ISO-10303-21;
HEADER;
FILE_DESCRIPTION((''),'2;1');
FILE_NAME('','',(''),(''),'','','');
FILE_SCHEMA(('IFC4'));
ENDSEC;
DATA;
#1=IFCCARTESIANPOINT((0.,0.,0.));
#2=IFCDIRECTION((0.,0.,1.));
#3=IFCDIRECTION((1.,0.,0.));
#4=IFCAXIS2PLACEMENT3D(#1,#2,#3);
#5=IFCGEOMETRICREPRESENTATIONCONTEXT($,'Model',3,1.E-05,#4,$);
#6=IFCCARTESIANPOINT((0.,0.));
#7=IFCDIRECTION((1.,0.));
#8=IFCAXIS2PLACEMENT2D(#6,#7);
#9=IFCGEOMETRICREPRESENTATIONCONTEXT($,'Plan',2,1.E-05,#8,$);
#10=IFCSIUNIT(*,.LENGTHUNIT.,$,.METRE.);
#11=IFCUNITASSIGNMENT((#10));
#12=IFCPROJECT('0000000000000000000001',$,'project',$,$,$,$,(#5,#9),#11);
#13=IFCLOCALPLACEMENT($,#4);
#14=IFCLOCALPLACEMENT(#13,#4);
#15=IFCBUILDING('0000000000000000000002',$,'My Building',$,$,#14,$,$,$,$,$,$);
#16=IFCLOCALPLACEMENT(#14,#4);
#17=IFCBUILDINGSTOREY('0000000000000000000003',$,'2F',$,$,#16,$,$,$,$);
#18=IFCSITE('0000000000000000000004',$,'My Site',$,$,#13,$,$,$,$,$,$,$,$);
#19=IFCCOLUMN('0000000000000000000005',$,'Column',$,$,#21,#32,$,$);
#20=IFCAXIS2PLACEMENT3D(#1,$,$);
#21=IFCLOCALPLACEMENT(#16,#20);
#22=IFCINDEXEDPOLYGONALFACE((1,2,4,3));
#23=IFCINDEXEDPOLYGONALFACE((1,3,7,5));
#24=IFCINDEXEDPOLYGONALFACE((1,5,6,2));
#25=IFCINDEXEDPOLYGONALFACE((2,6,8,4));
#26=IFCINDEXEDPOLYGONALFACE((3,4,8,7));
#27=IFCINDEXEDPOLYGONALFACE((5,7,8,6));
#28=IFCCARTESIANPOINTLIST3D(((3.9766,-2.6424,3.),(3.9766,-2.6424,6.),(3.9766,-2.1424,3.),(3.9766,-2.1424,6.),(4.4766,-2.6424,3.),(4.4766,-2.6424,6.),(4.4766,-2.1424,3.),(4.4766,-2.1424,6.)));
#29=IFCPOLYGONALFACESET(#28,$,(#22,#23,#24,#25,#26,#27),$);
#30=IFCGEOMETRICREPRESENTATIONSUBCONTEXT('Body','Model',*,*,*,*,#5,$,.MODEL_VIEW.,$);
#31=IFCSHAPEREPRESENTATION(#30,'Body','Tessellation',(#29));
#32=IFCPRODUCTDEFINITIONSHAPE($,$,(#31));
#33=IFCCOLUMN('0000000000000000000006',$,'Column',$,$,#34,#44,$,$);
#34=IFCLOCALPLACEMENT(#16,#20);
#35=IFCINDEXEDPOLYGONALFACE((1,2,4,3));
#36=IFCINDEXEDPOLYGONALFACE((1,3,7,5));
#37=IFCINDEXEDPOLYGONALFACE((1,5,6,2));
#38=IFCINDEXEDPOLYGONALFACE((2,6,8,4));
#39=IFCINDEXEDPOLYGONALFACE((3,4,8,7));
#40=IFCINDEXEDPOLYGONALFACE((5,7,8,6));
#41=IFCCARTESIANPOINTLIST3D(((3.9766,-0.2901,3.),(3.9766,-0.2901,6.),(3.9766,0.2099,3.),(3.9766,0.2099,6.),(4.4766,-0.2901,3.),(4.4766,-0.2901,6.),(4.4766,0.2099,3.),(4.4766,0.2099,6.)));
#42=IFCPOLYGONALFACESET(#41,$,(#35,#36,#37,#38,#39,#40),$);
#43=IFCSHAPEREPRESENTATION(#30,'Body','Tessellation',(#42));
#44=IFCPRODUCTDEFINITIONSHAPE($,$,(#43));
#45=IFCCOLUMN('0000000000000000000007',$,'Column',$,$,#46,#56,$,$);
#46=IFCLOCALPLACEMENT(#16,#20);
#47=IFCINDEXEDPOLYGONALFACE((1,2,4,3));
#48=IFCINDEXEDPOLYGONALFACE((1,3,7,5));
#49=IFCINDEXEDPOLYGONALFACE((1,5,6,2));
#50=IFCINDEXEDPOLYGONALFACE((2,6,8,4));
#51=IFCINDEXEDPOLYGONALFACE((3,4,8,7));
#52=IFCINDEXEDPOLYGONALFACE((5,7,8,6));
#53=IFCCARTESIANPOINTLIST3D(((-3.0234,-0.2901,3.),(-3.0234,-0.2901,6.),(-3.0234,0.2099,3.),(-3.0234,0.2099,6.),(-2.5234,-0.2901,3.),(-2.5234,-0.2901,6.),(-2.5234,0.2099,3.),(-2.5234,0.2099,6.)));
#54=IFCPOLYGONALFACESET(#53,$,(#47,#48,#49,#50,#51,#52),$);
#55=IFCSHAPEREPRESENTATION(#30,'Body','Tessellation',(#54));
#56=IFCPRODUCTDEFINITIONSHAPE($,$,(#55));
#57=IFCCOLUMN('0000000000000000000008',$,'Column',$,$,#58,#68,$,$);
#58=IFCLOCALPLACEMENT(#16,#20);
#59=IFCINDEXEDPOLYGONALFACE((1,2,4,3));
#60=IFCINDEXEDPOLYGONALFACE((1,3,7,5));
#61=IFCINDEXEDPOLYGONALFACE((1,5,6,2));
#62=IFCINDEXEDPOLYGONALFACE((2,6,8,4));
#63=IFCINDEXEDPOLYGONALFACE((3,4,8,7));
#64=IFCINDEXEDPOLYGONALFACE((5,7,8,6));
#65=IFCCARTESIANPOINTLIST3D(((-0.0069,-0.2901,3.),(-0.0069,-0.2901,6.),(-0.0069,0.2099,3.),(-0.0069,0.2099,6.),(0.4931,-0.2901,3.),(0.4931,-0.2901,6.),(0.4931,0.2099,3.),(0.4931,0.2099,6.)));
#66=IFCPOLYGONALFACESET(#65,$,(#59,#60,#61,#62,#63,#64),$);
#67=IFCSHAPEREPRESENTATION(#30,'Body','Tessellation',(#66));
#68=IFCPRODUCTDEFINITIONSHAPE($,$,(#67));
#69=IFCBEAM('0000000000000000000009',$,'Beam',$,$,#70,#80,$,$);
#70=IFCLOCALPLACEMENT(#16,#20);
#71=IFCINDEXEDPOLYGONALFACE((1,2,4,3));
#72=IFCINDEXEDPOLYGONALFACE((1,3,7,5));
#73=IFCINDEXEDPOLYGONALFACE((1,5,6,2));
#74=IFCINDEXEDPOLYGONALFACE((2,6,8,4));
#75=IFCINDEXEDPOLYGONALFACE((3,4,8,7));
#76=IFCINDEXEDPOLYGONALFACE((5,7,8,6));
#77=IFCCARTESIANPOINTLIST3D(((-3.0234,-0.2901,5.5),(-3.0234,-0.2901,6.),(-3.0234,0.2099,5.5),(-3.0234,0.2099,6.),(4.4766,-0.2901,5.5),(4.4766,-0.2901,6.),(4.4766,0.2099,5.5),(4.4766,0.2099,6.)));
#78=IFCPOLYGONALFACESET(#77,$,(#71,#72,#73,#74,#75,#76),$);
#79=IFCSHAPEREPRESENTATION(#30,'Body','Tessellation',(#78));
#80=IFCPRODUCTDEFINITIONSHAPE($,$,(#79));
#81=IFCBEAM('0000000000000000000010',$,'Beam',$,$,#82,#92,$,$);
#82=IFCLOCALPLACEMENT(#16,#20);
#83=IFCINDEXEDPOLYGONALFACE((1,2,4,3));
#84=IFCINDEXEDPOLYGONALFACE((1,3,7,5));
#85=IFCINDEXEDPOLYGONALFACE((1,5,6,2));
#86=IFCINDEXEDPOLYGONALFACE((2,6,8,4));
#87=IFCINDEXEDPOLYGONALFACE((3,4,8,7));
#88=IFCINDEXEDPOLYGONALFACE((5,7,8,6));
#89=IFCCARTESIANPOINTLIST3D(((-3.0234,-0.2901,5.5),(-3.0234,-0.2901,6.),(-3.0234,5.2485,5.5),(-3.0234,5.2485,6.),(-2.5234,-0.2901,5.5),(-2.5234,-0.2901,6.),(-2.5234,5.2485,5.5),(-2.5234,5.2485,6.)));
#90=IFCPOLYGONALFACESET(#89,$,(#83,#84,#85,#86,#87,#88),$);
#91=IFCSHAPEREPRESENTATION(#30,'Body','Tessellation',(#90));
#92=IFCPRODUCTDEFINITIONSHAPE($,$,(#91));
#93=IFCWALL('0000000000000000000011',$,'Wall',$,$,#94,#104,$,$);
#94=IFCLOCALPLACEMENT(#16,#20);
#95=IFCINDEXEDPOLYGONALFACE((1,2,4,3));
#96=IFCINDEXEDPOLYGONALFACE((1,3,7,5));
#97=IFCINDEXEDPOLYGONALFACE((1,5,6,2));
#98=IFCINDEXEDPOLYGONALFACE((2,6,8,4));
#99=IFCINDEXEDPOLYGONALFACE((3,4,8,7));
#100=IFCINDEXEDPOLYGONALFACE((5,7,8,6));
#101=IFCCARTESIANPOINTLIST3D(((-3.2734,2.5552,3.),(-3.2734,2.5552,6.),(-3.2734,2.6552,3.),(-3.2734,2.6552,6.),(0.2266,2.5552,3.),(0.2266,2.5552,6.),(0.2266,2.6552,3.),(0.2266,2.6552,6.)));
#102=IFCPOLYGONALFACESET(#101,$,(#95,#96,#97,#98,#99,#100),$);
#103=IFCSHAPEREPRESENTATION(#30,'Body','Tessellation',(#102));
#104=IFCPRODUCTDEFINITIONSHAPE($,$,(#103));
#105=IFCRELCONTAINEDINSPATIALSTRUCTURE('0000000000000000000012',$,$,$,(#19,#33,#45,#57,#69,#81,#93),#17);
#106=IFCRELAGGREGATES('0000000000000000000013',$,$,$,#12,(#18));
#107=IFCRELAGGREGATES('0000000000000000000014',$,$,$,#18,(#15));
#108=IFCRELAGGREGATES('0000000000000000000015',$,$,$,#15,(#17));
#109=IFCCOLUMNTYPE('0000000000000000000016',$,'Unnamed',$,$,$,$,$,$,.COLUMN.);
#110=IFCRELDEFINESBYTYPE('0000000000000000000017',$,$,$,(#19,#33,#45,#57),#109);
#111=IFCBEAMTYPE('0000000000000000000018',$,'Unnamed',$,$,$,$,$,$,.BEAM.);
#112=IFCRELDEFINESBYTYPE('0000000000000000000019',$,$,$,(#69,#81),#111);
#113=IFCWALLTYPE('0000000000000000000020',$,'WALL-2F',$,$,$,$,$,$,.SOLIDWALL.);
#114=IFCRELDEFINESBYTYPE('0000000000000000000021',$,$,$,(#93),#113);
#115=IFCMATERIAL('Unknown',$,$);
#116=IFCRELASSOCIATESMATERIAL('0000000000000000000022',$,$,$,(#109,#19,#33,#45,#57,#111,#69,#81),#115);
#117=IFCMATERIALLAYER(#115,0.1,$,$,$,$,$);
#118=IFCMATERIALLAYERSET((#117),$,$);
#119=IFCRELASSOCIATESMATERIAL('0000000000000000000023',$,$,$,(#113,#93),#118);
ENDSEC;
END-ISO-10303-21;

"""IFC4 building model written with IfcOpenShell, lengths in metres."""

from ifc_helpers import new_model, si_unit, frame, origin_with_axes, origin_2d_with_axis, place, context, subcontext, project, spatial, line, indexed_curve, rectangle, outline, extrude, material, layer, layer_set, layer_usage, material_profile, profile_set, profile_usage, type_object, element, save


model = new_model("IFC4")

# Units and contexts
model_context = context("Model", 3, precision=1e-05, world=origin_with_axes())
plan_context = context("Plan", 2, precision=1e-05, world=origin_2d_with_axis())
body_context_1 = subcontext(model_context, "Body", "Model", "MODEL_VIEW")
ifc_project = project(units=[si_unit("LENGTHUNIT", "METRE")], contexts=[model_context, plan_context])

# Site, building, storey
site_placement = place(None, origin_with_axes())
site = spatial("IfcSite", under=ifc_project, at=site_placement, Name="My Site")
building_placement = place(site_placement, origin_with_axes())
building = spatial("IfcBuilding", under=site, at=building_placement, Name="My Building")
storey_placement = place(building_placement, origin_with_axes())
storey = spatial("IfcBuildingStorey", under=building, at=storey_placement, Name="2F")

# Columns
ifc_material = material(Name="Unknown")
ifc_material_profile_1 = material_profile(ifc_material, rectangle(XDim=0.5, YDim=0.5))
ifc_profile_set_1 = profile_set([ifc_material_profile_1])
ifc_profile_usage_1 = profile_usage(ifc_profile_set_1, cardinal=7)
column_type = type_object("IfcColumnType", Name="Unnamed", PredefinedType="COLUMN", material=ifc_profile_set_1)
column_1_placement = place(storey_placement, frame((4.4766, -2.1424, 3.0), z_axis=(0.0, 0.0, 1.0), x_axis=(1.0, 0.0, 0.0)))
element("IfcColumn", 1, at=column_1_placement, inside=storey, type_object=column_type, material=ifc_profile_usage_1, Name="Column", context=body_context_1, shape_type="SweptSolid", body=[
    extrude(rectangle(XDim=0.5, YDim=0.5), frame((-0.25, -0.25, 0.0), z_axis=(0.0, 0.0, 1.0), x_axis=(1.0, 0.0, 0.0)), (0.0, 0.0, 1.0), 3.0),
])
ifc_profile_usage_2 = profile_usage(ifc_profile_set_1, cardinal=7)
column_2_placement = place(storey_placement, frame((4.4766, 0.2099, 3.0), z_axis=(0.0, 0.0, 1.0), x_axis=(1.0, 0.0, 0.0)))
element("IfcColumn", 2, at=column_2_placement, inside=storey, type_object=column_type, material=ifc_profile_usage_2, Name="Column", context=body_context_1, shape_type="SweptSolid", body=[
    extrude(rectangle(XDim=0.5, YDim=0.5), frame((-0.25, -0.25, 0.0), z_axis=(0.0, 0.0, 1.0), x_axis=(1.0, 0.0, 0.0)), (0.0, 0.0, 1.0), 3.0),
])
ifc_profile_usage_3 = profile_usage(ifc_profile_set_1, cardinal=7)
column_3_placement = place(storey_placement, frame((-2.5234, 0.2099, 3.0), z_axis=(0.0, 0.0, 1.0), x_axis=(1.0, 0.0, 0.0)))
element("IfcColumn", 3, at=column_3_placement, inside=storey, type_object=column_type, material=ifc_profile_usage_3, Name="Column", context=body_context_1, shape_type="SweptSolid", body=[
    extrude(rectangle(XDim=0.5, YDim=0.5), frame((-0.25, -0.25, 0.0), z_axis=(0.0, 0.0, 1.0), x_axis=(1.0, 0.0, 0.0)), (0.0, 0.0, 1.0), 3.0),
])
ifc_profile_usage_4 = profile_usage(ifc_profile_set_1, cardinal=7)
column_4_placement = place(storey_placement, frame((0.4931, 0.2099, 3.0), z_axis=(0.0, 0.0, 1.0), x_axis=(1.0, 0.0, 0.0)))
element("IfcColumn", 4, at=column_4_placement, inside=storey, type_object=column_type, material=ifc_profile_usage_4, Name="Column", context=body_context_1, shape_type="SweptSolid", body=[
    extrude(rectangle(XDim=0.5, YDim=0.5), frame((-0.25, -0.25, 0.0), z_axis=(0.0, 0.0, 1.0), x_axis=(1.0, 0.0, 0.0)), (0.0, 0.0, 1.0), 3.0),
])

# Beams
ifc_material_profile_2 = material_profile(ifc_material, rectangle(XDim=0.5, YDim=0.5))
ifc_profile_set_2 = profile_set([ifc_material_profile_2])
ifc_profile_usage_5 = profile_usage(ifc_profile_set_2, cardinal=7)
beam_type = type_object("IfcBeamType", Name="Unnamed", PredefinedType="BEAM", material=ifc_profile_set_2)
beam_1_placement = place(storey_placement, frame((-3.0234, 0.2099, 6.0), z_axis=(1.0, 0.0, 0.0), x_axis=(0.0, 1.0, 0.0)))
element("IfcBeam", 5, at=beam_1_placement, inside=storey, type_object=beam_type, material=ifc_profile_usage_5, Name="Beam", context=body_context_1, shape_type="SweptSolid", body=[
    extrude(rectangle(XDim=0.5, YDim=0.5), frame((-0.25, -0.25, 0.0), z_axis=(0.0, 0.0, 1.0), x_axis=(1.0, 0.0, 0.0)), (0.0, 0.0, 1.0), 7.5),
])
ifc_profile_usage_6 = profile_usage(ifc_profile_set_2, cardinal=7)
beam_2_placement = place(storey_placement, frame((-3.0234, -0.2901, 6.0), z_axis=(0.0, 1.0, 0.0), x_axis=(-1.0, 0.0, 0.0)))
element("IfcBeam", 6, at=beam_2_placement, inside=storey, type_object=beam_type, material=ifc_profile_usage_6, Name="Beam", context=body_context_1, shape_type="SweptSolid", body=[
    extrude(rectangle(XDim=0.5, YDim=0.5), frame((-0.25, -0.25, 0.0), z_axis=(0.0, 0.0, 1.0), x_axis=(1.0, 0.0, 0.0)), (0.0, 0.0, 1.0), 5.5386),
])

# Wall
ifc_layer_1 = layer(ifc_material, 0.1)
ifc_layer_set_1 = layer_set([ifc_layer_1])
ifc_layer_usage_1 = layer_usage(ifc_layer_set_1, "AXIS2", "POSITIVE", 0.0)
wall_type_1 = type_object("IfcWallType", Name="WALL-2F", PredefinedType="SOLIDWALL", material=ifc_layer_set_1)
wall_1_placement = place(storey_placement, frame((-3.2734, 2.5552, 3.0), z_axis=(0.0, 0.0, 1.0), x_axis=(1.0, 0.0, 0.0)))
element("IfcWall", 7, at=wall_1_placement, inside=storey, type_object=wall_type_1, material=ifc_layer_usage_1, Name="Wall", context=body_context_1, shape_type="SweptSolid", body=[
    extrude(outline(indexed_curve([(0.0, 0.0), (0.0, 0.1), (3.5, 0.1), (3.5, 0.0)], segments=[line(1, 2, 3, 4, 1)])), origin_with_axes(), (0.0, 0.0, 1.0), 3.0),
])

save(model, "model.ifc")
